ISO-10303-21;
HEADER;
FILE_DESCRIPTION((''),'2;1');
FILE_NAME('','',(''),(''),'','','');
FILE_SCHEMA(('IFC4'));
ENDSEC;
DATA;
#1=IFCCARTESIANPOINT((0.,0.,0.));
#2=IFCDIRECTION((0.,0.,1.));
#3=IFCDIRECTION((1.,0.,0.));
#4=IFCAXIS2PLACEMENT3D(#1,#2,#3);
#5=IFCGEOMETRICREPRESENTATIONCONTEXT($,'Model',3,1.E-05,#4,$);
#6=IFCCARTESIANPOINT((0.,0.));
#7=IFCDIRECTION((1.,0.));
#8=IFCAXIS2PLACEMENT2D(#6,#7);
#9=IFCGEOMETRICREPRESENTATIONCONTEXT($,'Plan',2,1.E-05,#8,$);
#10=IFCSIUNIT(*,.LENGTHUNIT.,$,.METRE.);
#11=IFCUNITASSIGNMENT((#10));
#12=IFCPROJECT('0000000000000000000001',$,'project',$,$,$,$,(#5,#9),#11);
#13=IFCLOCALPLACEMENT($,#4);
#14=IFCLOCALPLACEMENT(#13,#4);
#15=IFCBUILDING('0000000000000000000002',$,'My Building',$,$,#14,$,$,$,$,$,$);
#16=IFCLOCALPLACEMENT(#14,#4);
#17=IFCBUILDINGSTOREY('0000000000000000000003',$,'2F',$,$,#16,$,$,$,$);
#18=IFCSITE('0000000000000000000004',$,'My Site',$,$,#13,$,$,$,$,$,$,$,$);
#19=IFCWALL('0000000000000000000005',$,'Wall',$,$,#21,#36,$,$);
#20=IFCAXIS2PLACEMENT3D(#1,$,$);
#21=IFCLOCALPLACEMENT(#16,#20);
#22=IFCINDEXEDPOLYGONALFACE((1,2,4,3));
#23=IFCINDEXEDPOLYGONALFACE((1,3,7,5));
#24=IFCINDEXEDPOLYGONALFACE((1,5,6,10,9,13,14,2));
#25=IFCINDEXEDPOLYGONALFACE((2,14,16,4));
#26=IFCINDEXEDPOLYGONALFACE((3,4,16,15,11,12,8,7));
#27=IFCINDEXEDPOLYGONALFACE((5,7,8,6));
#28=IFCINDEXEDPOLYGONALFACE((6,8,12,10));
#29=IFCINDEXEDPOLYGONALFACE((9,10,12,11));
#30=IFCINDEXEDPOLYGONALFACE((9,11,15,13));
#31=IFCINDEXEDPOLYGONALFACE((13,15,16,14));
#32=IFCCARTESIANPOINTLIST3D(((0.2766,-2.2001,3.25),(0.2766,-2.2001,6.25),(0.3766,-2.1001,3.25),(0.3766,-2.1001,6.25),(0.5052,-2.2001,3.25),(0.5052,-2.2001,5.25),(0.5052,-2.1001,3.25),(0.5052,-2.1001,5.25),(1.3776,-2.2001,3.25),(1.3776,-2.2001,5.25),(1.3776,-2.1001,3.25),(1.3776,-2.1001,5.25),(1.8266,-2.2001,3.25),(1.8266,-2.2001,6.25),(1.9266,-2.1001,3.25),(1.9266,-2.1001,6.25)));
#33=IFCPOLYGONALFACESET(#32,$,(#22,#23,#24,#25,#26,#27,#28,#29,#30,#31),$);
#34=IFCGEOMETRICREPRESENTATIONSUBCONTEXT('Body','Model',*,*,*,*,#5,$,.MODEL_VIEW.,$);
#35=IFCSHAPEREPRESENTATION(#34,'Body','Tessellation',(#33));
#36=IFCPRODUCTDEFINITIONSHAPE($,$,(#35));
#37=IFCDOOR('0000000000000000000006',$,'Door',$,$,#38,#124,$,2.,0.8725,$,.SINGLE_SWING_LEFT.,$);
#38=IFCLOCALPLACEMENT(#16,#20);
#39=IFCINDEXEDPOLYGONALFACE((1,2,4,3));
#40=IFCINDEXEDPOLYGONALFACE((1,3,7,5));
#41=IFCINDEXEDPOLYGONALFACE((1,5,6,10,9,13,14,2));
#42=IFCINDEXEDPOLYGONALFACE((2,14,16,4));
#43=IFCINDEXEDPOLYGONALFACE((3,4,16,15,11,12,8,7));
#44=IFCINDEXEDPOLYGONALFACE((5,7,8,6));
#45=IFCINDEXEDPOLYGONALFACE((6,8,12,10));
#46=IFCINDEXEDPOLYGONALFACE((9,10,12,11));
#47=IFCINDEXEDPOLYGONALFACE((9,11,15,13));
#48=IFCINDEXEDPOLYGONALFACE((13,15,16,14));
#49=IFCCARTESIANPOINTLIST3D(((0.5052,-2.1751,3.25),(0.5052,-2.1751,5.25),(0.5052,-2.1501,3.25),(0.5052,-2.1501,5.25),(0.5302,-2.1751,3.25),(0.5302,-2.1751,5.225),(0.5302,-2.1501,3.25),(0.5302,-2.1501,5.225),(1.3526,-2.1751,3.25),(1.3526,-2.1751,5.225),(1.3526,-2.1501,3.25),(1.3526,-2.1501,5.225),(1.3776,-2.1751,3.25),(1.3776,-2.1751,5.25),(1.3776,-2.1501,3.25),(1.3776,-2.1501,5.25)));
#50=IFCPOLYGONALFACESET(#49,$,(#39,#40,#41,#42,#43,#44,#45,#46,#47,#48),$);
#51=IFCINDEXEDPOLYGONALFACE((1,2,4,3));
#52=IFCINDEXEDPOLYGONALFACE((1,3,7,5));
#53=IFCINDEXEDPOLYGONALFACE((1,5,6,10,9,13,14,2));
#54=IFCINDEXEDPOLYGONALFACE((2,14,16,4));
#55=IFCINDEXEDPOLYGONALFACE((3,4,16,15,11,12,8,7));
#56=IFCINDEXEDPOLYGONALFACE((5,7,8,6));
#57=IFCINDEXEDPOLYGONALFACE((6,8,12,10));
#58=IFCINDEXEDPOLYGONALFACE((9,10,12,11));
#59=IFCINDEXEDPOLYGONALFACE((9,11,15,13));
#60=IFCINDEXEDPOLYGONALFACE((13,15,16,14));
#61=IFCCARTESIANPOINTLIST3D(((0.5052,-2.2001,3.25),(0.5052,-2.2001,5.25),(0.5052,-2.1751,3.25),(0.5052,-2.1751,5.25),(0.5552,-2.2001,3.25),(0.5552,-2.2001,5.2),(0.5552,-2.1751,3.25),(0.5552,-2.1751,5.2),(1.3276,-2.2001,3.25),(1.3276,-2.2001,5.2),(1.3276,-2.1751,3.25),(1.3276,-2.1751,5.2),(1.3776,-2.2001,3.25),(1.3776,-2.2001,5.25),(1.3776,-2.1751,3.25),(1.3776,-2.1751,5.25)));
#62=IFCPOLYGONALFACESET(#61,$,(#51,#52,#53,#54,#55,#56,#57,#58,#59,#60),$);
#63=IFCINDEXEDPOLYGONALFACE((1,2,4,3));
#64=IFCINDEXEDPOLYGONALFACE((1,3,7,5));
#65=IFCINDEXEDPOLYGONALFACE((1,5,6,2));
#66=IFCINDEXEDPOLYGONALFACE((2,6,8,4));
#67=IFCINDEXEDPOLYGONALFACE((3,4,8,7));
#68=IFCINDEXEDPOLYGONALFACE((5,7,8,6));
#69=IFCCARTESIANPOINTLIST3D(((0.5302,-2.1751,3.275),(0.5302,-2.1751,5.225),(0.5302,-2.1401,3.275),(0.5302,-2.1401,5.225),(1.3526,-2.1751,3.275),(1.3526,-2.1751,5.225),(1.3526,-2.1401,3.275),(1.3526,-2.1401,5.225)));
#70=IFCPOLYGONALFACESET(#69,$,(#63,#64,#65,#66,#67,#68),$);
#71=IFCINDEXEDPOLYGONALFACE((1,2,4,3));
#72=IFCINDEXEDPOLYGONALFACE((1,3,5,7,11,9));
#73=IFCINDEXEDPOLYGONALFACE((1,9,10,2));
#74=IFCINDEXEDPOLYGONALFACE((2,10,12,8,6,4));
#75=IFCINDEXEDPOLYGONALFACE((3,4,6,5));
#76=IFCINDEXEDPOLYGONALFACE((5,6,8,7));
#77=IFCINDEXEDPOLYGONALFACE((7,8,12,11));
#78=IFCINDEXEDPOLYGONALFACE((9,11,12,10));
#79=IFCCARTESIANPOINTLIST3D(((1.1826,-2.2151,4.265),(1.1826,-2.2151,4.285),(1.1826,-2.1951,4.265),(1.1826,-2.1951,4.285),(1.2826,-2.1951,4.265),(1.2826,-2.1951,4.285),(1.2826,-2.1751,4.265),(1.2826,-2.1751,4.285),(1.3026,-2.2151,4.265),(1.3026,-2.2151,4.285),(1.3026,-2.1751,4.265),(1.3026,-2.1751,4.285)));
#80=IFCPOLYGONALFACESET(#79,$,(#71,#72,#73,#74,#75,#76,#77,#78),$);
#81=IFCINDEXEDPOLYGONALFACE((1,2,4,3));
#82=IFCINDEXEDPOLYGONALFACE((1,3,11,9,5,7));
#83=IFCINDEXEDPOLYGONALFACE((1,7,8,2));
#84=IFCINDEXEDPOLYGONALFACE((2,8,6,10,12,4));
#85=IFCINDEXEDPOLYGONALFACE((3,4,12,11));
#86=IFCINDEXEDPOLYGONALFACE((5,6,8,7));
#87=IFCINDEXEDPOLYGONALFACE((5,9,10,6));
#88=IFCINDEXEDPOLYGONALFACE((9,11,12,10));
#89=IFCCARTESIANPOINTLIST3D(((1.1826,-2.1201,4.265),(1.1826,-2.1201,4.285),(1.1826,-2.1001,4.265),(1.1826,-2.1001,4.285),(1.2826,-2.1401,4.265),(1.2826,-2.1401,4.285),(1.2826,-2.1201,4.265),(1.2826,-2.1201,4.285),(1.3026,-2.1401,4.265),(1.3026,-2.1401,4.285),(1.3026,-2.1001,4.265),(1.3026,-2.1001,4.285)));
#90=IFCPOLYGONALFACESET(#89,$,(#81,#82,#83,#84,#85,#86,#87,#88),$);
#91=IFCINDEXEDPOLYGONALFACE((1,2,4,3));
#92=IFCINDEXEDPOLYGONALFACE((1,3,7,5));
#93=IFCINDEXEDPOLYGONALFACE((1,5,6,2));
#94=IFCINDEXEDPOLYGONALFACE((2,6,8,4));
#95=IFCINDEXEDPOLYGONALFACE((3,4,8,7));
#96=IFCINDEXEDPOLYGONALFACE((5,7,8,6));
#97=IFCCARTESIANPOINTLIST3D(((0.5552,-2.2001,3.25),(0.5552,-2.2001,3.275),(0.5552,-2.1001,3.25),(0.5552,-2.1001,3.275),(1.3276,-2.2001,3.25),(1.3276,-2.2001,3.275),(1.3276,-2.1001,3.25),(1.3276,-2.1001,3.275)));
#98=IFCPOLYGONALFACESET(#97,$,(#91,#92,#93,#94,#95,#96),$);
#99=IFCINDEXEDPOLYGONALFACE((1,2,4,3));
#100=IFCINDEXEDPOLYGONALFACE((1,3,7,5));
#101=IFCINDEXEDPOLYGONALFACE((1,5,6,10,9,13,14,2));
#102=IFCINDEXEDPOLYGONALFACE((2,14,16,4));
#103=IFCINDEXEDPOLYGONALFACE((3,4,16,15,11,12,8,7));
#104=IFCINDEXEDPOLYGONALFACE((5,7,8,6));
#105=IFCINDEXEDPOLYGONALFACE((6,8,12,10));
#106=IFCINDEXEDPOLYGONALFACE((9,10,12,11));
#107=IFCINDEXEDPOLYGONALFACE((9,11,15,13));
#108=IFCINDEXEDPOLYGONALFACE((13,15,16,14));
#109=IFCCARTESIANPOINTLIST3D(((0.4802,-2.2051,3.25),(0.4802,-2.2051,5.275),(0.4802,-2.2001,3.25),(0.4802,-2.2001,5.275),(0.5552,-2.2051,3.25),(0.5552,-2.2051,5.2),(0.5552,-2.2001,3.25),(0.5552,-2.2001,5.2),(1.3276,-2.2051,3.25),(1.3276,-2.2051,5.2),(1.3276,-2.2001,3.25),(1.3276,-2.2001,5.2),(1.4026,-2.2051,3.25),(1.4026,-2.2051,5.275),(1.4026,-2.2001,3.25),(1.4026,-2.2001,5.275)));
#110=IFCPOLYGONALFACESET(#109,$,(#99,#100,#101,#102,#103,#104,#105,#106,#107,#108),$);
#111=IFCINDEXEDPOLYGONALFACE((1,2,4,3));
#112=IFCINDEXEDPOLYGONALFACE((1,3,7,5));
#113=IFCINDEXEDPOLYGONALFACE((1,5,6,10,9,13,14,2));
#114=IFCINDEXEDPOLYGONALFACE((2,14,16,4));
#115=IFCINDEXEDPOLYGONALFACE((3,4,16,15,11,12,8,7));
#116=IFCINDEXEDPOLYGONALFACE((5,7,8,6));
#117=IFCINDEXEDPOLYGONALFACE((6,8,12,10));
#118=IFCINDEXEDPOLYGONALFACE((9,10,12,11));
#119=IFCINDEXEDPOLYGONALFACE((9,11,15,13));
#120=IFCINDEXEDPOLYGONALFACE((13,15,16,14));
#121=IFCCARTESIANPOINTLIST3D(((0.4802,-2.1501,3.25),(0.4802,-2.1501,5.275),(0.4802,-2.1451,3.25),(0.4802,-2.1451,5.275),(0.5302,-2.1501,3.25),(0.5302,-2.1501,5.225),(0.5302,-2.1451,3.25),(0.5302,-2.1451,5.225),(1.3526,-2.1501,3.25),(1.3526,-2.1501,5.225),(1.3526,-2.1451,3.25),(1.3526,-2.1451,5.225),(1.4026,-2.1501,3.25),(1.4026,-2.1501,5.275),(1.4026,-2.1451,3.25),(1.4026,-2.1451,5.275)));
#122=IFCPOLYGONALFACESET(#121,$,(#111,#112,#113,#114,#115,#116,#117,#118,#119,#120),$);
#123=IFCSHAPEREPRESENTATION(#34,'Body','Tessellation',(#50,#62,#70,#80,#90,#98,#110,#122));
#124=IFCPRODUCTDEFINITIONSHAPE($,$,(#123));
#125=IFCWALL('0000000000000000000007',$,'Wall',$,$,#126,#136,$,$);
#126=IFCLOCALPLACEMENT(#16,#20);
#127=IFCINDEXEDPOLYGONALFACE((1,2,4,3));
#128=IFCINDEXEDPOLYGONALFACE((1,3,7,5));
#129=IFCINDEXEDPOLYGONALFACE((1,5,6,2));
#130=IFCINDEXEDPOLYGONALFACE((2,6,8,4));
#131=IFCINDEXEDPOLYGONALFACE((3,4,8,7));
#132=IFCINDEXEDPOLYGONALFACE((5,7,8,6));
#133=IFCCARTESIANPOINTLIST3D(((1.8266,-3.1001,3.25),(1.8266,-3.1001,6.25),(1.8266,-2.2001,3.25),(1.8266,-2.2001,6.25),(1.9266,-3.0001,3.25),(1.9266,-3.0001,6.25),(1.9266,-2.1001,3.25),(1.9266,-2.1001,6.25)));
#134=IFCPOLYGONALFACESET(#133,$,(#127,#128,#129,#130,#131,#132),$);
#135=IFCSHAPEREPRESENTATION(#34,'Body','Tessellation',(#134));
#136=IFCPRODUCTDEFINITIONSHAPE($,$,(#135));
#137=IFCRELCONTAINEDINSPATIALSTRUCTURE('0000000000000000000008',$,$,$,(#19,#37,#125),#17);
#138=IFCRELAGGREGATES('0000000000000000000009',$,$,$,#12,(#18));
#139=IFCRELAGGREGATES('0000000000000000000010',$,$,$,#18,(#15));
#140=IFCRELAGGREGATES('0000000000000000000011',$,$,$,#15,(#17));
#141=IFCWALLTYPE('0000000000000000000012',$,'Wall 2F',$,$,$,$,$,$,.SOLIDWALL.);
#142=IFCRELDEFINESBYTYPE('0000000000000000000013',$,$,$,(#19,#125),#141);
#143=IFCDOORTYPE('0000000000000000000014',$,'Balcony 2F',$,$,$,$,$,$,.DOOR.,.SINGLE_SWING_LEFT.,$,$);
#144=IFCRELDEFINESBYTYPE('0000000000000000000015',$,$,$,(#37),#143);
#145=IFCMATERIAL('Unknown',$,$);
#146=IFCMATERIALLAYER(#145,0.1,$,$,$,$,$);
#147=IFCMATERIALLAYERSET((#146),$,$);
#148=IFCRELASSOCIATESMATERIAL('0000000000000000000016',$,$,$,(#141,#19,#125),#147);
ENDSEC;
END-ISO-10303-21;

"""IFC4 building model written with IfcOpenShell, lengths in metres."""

from ifc_helpers import new_model, entity, si_unit, frame, origin_with_axes, origin_2d_with_axis, place, context, subcontext, project, spatial, line, indexed_curve, outline, extrude, shape, source, transform, mapped, material, layer, layer_set, layer_usage, type_object, type_shapes, element, fill, save


model = new_model("IFC4")

# Units and contexts
model_context = context("Model", 3, precision=1e-05, world=origin_with_axes())
plan_context = context("Plan", 2, precision=1e-05, world=origin_2d_with_axis())
body_context_1 = subcontext(model_context, "Body", "Model", "MODEL_VIEW")
body_context_2 = subcontext(plan_context, "Body", "Plan", "PLAN_VIEW")
ifc_project = project(units=[si_unit("LENGTHUNIT", "METRE")], contexts=[model_context, plan_context])

# Site, building, storey
site_placement = place(None, origin_with_axes())
site = spatial("IfcSite", under=ifc_project, at=site_placement, Name="My Site")
building_placement = place(site_placement, origin_with_axes())
building = spatial("IfcBuilding", under=site, at=building_placement, Name="My Building")
storey_placement = place(building_placement, origin_with_axes())
storey = spatial("IfcBuildingStorey", under=building, at=storey_placement, Name="2F")

# Shared definitions
ifc_material = material(Name="Unknown")

# Shared definitions
ifc_layer = layer(ifc_material, 0.1)
ifc_layer_set = layer_set([ifc_layer])
wall_type = type_object("IfcWallType", Name="Wall 2F", PredefinedType="SOLIDWALL", material=ifc_layer_set)

# Wall, opening, door
ifc_layer_usage_1 = layer_usage(ifc_layer_set, "AXIS2", "POSITIVE", 0.0)
wall_1_placement = place(storey_placement, frame((0.2766, -2.2001, 3.25), z_axis=(0.0, 0.0, 1.0), x_axis=(1.0, 0.0, 0.0)))
wall_1 = element("IfcWall", 1, at=wall_1_placement, inside=storey, type_object=wall_type, material=ifc_layer_usage_1, Name="Wall", context=body_context_1, shape_type="SweptSolid", body=[
    extrude(outline(indexed_curve([(0.0, 0.0), (0.1, 0.1), (1.65, 0.1), (1.55, 0.0)], segments=[line(1, 2, 3, 4, 1)])), origin_with_axes(), (0.0, 0.0, 1.0), 3.0),
])
shared_shape_1 = source(origin_with_axes(), body_context_1, "Body", "SweptSolid", [
    extrude(outline(indexed_curve([(0.0, 0.0), (0.8725, 0.0), (0.8725, 2.0), (0.0, 2.0)], segments=[line(1, 2, 3, 4, 1)])), frame((0.0, -0.6, 0.0), z_axis=(0.0, -1.0, 0.0), x_axis=(1.0, 0.0, 0.0)), (0.0, 0.0, -1.0), 1.2),
])
opening_1_placement = place(wall_1_placement, frame((0.2286, 0.0, 0.0), z_axis=(0.0, 0.0, 1.0), x_axis=(1.0, 0.0, 0.0)))
opening_1 = element("IfcOpeningElement", 2, at=opening_1_placement, cuts=wall_1, PredefinedType="OPENING", context=body_context_1, shape_type="MappedRepresentation", body=[
    mapped(shared_shape_1, transform((0.0, 0.0, 0.0), x_axis=(1.0, 0.0, 0.0), y_axis=(0.0, 1.0, 0.0), z_axis=(0.0, 0.0, 1.0), scale=1.0)),
])
door_type_1 = type_object("IfcDoorType", Name="Balcony 2F", OperationType="SINGLE_SWING_LEFT", PredefinedType="DOOR")
shared_shape_2 = source(origin_with_axes(), body_context_1, "Body", "SweptSolid", [
    extrude(outline(indexed_curve([(0.0, 0.0), (0.0, 2.0), (0.8725, 2.0), (0.8725, 0.0), (0.8475, 0.0), (0.8475, 1.975), (0.025, 1.975), (0.025, 0.0)], segments=[line(1, 2, 3, 4, 5, 6, 7, 8, 1)])), frame((0.0, 0.025, 0.0), z_axis=(0.0, -1.0, 0.0), x_axis=(1.0, 0.0, 0.0)), (0.0, 0.0, -1.0), 0.025),
    extrude(outline(indexed_curve([(0.0, 0.0), (0.0, 2.0), (0.8725, 2.0), (0.8725, 0.0), (0.8225, 0.0), (0.8225, 1.95), (0.05, 1.95), (0.05, 0.0)], segments=[line(1, 2, 3, 4, 5, 6, 7, 8, 1)])), frame((0.0, 0.0, 0.0), z_axis=(0.0, -1.0, 0.0), x_axis=(1.0, 0.0, 0.0)), (0.0, 0.0, -1.0), 0.025),
    extrude(outline(indexed_curve([(0.0, 0.0), (0.8225, 0.0), (0.8225, 0.035), (0.0, 0.035)], segments=[line(1, 2, 3, 4, 1)])), frame((0.025, 0.025, 0.025), z_axis=(0.0, 0.0, 1.0), x_axis=(1.0, 0.0, 0.0)), (0.0, 0.0, 1.0), 1.95),
    extrude(outline(indexed_curve([(0.0, 0.0), (0.0, -0.04), (-0.12, -0.04), (-0.12, -0.02), (-0.02, -0.02), (-0.02, 0.0)], segments=[line(1, 2, 3, 4, 5, 6, 1)])), frame((0.7975, 0.025, 1.015), z_axis=(0.0, 0.0, 1.0), x_axis=(1.0, 0.0, 0.0)), (0.0, 0.0, 1.0), 0.02),
    extrude(outline(indexed_curve([(0.0, 0.0), (0.0, 0.04), (-0.12, 0.04), (-0.12, 0.02), (-0.02, 0.02), (-0.02, 0.0)], segments=[line(1, 2, 3, 4, 5, 6, 1)])), frame((0.7975, 0.06, 1.015), z_axis=(0.0, 0.0, 1.0), x_axis=(1.0, 0.0, 0.0)), (0.0, 0.0, 1.0), 0.02),
    extrude(outline(indexed_curve([(0.0, 0.0), (0.7725, 0.0), (0.7725, 0.1), (0.0, 0.1)], segments=[line(1, 2, 3, 4, 1)])), frame((0.05, 0.0, 0.0), z_axis=(0.0, 0.0, 1.0), x_axis=(1.0, 0.0, 0.0)), (0.0, 0.0, 1.0), 0.025),
    extrude(outline(indexed_curve([(0.0, 0.0), (0.0, 2.025), (0.9225, 2.025), (0.9225, 0.0), (0.8475, 0.0), (0.8475, 1.95), (0.075, 1.95), (0.075, 0.0)], segments=[line(1, 2, 3, 4, 5, 6, 7, 8, 1)])), frame((-0.025, -0.005, 0.0), z_axis=(0.0, -1.0, 0.0), x_axis=(1.0, 0.0, 0.0)), (0.0, 0.0, -1.0), 0.005),
    extrude(outline(indexed_curve([(0.0, 0.0), (0.0, 2.025), (0.9225, 2.025), (0.9225, 0.0), (0.8725, 0.0), (0.8725, 1.975), (0.05, 1.975), (0.05, 0.0)], segments=[line(1, 2, 3, 4, 5, 6, 7, 8, 1)])), frame((-0.025, 0.05, 0.0), z_axis=(0.0, -1.0, 0.0), x_axis=(1.0, 0.0, 0.0)), (0.0, 0.0, -1.0), 0.005),
])
shared_shape_3 = source(origin_with_axes(), body_context_2, "Body", "Curve2D", [
    entity("IfcIndexedPolyCurve", entity("IfcCartesianPointList2D", [[0.0, 0.0], [0.0, 0.05], [0.025, 0.05], [0.025, 0.025], [0.05, 0.025], [0.05, 0.0]]), [entity("IfcLineIndex", [1, 2, 3, 4, 5, 6, 1])]),
    entity("IfcIndexedPolyCurve", entity("IfcCartesianPointList2D", [[0.8725, 0.0], [0.8725, 0.05], [0.8475, 0.05], [0.8475, 0.025], [0.8225, 0.025], [0.8225, 0.0]]), [entity("IfcLineIndex", [1, 2, 3, 4, 5, 6, 1])]),
    entity("IfcTrimmedCurve", entity("IfcEllipse", entity("IfcAxis2Placement2D", entity("IfcCartesianPoint", [0.06, 0.05]), entity("IfcDirection", [1.0, 0.0])), 0.7875, 0.8225), [entity("IfcCartesianPoint", [0.8475, 0.05])], [entity("IfcCartesianPoint", [0.06, 0.8725])], True, "CARTESIAN"),
    entity("IfcIndexedPolyCurve", entity("IfcCartesianPointList2D", [[0.025, 0.05], [0.06, 0.05], [0.06, 0.8725], [0.025, 0.8725]]), [entity("IfcLineIndex", [1, 2, 3, 4, 1])]),
])
type_shapes(door_type_1, [shared_shape_2, shared_shape_3])
door_1_placement = place(opening_1_placement, frame((0.0, 0.0, 0.0), z_axis=(0.0, 0.0, 1.0), x_axis=(1.0, 0.0, 0.0)))
door_1 = element("IfcDoor", 3, at=door_1_placement, inside=storey, type_object=door_type_1, Name="Door", OperationType="SINGLE_SWING_LEFT", OverallHeight=2.0, OverallWidth=0.8725, shapes=[
    shape(body_context_1, "Body", "MappedRepresentation", [mapped(shared_shape_2, transform((0.0, 0.0, 0.0), x_axis=(1.0, 0.0, 0.0), y_axis=(0.0, 1.0, 0.0), z_axis=(0.0, 0.0, 1.0), scale=1.0))]),
    shape(body_context_2, "Body", "MappedRepresentation", [mapped(shared_shape_3, transform((0.0, 0.0, 0.0), x_axis=(1.0, 0.0, 0.0), y_axis=(0.0, 1.0, 0.0), z_axis=(0.0, 0.0, 1.0), scale=1.0))]),
])
fill(opening_1, door_1)

# Wall
ifc_layer_usage_2 = layer_usage(ifc_layer_set, "AXIS2", "POSITIVE", 0.0)
wall_2_placement = place(storey_placement, frame((1.8266, -2.2001, 3.25), z_axis=(0.0, 0.0, 1.0), x_axis=(0.0, -1.0, 0.0)))
element("IfcWall", 4, at=wall_2_placement, inside=storey, type_object=wall_type, material=ifc_layer_usage_2, Name="Wall", context=body_context_1, shape_type="SweptSolid", body=[
    extrude(outline(indexed_curve([(0.0, 0.0), (-0.1, 0.1), (0.8, 0.1), (0.9, 0.0)], segments=[line(1, 2, 3, 4, 1)])), origin_with_axes(), (0.0, 0.0, 1.0), 3.0),
])

save(model, "model.ifc")
